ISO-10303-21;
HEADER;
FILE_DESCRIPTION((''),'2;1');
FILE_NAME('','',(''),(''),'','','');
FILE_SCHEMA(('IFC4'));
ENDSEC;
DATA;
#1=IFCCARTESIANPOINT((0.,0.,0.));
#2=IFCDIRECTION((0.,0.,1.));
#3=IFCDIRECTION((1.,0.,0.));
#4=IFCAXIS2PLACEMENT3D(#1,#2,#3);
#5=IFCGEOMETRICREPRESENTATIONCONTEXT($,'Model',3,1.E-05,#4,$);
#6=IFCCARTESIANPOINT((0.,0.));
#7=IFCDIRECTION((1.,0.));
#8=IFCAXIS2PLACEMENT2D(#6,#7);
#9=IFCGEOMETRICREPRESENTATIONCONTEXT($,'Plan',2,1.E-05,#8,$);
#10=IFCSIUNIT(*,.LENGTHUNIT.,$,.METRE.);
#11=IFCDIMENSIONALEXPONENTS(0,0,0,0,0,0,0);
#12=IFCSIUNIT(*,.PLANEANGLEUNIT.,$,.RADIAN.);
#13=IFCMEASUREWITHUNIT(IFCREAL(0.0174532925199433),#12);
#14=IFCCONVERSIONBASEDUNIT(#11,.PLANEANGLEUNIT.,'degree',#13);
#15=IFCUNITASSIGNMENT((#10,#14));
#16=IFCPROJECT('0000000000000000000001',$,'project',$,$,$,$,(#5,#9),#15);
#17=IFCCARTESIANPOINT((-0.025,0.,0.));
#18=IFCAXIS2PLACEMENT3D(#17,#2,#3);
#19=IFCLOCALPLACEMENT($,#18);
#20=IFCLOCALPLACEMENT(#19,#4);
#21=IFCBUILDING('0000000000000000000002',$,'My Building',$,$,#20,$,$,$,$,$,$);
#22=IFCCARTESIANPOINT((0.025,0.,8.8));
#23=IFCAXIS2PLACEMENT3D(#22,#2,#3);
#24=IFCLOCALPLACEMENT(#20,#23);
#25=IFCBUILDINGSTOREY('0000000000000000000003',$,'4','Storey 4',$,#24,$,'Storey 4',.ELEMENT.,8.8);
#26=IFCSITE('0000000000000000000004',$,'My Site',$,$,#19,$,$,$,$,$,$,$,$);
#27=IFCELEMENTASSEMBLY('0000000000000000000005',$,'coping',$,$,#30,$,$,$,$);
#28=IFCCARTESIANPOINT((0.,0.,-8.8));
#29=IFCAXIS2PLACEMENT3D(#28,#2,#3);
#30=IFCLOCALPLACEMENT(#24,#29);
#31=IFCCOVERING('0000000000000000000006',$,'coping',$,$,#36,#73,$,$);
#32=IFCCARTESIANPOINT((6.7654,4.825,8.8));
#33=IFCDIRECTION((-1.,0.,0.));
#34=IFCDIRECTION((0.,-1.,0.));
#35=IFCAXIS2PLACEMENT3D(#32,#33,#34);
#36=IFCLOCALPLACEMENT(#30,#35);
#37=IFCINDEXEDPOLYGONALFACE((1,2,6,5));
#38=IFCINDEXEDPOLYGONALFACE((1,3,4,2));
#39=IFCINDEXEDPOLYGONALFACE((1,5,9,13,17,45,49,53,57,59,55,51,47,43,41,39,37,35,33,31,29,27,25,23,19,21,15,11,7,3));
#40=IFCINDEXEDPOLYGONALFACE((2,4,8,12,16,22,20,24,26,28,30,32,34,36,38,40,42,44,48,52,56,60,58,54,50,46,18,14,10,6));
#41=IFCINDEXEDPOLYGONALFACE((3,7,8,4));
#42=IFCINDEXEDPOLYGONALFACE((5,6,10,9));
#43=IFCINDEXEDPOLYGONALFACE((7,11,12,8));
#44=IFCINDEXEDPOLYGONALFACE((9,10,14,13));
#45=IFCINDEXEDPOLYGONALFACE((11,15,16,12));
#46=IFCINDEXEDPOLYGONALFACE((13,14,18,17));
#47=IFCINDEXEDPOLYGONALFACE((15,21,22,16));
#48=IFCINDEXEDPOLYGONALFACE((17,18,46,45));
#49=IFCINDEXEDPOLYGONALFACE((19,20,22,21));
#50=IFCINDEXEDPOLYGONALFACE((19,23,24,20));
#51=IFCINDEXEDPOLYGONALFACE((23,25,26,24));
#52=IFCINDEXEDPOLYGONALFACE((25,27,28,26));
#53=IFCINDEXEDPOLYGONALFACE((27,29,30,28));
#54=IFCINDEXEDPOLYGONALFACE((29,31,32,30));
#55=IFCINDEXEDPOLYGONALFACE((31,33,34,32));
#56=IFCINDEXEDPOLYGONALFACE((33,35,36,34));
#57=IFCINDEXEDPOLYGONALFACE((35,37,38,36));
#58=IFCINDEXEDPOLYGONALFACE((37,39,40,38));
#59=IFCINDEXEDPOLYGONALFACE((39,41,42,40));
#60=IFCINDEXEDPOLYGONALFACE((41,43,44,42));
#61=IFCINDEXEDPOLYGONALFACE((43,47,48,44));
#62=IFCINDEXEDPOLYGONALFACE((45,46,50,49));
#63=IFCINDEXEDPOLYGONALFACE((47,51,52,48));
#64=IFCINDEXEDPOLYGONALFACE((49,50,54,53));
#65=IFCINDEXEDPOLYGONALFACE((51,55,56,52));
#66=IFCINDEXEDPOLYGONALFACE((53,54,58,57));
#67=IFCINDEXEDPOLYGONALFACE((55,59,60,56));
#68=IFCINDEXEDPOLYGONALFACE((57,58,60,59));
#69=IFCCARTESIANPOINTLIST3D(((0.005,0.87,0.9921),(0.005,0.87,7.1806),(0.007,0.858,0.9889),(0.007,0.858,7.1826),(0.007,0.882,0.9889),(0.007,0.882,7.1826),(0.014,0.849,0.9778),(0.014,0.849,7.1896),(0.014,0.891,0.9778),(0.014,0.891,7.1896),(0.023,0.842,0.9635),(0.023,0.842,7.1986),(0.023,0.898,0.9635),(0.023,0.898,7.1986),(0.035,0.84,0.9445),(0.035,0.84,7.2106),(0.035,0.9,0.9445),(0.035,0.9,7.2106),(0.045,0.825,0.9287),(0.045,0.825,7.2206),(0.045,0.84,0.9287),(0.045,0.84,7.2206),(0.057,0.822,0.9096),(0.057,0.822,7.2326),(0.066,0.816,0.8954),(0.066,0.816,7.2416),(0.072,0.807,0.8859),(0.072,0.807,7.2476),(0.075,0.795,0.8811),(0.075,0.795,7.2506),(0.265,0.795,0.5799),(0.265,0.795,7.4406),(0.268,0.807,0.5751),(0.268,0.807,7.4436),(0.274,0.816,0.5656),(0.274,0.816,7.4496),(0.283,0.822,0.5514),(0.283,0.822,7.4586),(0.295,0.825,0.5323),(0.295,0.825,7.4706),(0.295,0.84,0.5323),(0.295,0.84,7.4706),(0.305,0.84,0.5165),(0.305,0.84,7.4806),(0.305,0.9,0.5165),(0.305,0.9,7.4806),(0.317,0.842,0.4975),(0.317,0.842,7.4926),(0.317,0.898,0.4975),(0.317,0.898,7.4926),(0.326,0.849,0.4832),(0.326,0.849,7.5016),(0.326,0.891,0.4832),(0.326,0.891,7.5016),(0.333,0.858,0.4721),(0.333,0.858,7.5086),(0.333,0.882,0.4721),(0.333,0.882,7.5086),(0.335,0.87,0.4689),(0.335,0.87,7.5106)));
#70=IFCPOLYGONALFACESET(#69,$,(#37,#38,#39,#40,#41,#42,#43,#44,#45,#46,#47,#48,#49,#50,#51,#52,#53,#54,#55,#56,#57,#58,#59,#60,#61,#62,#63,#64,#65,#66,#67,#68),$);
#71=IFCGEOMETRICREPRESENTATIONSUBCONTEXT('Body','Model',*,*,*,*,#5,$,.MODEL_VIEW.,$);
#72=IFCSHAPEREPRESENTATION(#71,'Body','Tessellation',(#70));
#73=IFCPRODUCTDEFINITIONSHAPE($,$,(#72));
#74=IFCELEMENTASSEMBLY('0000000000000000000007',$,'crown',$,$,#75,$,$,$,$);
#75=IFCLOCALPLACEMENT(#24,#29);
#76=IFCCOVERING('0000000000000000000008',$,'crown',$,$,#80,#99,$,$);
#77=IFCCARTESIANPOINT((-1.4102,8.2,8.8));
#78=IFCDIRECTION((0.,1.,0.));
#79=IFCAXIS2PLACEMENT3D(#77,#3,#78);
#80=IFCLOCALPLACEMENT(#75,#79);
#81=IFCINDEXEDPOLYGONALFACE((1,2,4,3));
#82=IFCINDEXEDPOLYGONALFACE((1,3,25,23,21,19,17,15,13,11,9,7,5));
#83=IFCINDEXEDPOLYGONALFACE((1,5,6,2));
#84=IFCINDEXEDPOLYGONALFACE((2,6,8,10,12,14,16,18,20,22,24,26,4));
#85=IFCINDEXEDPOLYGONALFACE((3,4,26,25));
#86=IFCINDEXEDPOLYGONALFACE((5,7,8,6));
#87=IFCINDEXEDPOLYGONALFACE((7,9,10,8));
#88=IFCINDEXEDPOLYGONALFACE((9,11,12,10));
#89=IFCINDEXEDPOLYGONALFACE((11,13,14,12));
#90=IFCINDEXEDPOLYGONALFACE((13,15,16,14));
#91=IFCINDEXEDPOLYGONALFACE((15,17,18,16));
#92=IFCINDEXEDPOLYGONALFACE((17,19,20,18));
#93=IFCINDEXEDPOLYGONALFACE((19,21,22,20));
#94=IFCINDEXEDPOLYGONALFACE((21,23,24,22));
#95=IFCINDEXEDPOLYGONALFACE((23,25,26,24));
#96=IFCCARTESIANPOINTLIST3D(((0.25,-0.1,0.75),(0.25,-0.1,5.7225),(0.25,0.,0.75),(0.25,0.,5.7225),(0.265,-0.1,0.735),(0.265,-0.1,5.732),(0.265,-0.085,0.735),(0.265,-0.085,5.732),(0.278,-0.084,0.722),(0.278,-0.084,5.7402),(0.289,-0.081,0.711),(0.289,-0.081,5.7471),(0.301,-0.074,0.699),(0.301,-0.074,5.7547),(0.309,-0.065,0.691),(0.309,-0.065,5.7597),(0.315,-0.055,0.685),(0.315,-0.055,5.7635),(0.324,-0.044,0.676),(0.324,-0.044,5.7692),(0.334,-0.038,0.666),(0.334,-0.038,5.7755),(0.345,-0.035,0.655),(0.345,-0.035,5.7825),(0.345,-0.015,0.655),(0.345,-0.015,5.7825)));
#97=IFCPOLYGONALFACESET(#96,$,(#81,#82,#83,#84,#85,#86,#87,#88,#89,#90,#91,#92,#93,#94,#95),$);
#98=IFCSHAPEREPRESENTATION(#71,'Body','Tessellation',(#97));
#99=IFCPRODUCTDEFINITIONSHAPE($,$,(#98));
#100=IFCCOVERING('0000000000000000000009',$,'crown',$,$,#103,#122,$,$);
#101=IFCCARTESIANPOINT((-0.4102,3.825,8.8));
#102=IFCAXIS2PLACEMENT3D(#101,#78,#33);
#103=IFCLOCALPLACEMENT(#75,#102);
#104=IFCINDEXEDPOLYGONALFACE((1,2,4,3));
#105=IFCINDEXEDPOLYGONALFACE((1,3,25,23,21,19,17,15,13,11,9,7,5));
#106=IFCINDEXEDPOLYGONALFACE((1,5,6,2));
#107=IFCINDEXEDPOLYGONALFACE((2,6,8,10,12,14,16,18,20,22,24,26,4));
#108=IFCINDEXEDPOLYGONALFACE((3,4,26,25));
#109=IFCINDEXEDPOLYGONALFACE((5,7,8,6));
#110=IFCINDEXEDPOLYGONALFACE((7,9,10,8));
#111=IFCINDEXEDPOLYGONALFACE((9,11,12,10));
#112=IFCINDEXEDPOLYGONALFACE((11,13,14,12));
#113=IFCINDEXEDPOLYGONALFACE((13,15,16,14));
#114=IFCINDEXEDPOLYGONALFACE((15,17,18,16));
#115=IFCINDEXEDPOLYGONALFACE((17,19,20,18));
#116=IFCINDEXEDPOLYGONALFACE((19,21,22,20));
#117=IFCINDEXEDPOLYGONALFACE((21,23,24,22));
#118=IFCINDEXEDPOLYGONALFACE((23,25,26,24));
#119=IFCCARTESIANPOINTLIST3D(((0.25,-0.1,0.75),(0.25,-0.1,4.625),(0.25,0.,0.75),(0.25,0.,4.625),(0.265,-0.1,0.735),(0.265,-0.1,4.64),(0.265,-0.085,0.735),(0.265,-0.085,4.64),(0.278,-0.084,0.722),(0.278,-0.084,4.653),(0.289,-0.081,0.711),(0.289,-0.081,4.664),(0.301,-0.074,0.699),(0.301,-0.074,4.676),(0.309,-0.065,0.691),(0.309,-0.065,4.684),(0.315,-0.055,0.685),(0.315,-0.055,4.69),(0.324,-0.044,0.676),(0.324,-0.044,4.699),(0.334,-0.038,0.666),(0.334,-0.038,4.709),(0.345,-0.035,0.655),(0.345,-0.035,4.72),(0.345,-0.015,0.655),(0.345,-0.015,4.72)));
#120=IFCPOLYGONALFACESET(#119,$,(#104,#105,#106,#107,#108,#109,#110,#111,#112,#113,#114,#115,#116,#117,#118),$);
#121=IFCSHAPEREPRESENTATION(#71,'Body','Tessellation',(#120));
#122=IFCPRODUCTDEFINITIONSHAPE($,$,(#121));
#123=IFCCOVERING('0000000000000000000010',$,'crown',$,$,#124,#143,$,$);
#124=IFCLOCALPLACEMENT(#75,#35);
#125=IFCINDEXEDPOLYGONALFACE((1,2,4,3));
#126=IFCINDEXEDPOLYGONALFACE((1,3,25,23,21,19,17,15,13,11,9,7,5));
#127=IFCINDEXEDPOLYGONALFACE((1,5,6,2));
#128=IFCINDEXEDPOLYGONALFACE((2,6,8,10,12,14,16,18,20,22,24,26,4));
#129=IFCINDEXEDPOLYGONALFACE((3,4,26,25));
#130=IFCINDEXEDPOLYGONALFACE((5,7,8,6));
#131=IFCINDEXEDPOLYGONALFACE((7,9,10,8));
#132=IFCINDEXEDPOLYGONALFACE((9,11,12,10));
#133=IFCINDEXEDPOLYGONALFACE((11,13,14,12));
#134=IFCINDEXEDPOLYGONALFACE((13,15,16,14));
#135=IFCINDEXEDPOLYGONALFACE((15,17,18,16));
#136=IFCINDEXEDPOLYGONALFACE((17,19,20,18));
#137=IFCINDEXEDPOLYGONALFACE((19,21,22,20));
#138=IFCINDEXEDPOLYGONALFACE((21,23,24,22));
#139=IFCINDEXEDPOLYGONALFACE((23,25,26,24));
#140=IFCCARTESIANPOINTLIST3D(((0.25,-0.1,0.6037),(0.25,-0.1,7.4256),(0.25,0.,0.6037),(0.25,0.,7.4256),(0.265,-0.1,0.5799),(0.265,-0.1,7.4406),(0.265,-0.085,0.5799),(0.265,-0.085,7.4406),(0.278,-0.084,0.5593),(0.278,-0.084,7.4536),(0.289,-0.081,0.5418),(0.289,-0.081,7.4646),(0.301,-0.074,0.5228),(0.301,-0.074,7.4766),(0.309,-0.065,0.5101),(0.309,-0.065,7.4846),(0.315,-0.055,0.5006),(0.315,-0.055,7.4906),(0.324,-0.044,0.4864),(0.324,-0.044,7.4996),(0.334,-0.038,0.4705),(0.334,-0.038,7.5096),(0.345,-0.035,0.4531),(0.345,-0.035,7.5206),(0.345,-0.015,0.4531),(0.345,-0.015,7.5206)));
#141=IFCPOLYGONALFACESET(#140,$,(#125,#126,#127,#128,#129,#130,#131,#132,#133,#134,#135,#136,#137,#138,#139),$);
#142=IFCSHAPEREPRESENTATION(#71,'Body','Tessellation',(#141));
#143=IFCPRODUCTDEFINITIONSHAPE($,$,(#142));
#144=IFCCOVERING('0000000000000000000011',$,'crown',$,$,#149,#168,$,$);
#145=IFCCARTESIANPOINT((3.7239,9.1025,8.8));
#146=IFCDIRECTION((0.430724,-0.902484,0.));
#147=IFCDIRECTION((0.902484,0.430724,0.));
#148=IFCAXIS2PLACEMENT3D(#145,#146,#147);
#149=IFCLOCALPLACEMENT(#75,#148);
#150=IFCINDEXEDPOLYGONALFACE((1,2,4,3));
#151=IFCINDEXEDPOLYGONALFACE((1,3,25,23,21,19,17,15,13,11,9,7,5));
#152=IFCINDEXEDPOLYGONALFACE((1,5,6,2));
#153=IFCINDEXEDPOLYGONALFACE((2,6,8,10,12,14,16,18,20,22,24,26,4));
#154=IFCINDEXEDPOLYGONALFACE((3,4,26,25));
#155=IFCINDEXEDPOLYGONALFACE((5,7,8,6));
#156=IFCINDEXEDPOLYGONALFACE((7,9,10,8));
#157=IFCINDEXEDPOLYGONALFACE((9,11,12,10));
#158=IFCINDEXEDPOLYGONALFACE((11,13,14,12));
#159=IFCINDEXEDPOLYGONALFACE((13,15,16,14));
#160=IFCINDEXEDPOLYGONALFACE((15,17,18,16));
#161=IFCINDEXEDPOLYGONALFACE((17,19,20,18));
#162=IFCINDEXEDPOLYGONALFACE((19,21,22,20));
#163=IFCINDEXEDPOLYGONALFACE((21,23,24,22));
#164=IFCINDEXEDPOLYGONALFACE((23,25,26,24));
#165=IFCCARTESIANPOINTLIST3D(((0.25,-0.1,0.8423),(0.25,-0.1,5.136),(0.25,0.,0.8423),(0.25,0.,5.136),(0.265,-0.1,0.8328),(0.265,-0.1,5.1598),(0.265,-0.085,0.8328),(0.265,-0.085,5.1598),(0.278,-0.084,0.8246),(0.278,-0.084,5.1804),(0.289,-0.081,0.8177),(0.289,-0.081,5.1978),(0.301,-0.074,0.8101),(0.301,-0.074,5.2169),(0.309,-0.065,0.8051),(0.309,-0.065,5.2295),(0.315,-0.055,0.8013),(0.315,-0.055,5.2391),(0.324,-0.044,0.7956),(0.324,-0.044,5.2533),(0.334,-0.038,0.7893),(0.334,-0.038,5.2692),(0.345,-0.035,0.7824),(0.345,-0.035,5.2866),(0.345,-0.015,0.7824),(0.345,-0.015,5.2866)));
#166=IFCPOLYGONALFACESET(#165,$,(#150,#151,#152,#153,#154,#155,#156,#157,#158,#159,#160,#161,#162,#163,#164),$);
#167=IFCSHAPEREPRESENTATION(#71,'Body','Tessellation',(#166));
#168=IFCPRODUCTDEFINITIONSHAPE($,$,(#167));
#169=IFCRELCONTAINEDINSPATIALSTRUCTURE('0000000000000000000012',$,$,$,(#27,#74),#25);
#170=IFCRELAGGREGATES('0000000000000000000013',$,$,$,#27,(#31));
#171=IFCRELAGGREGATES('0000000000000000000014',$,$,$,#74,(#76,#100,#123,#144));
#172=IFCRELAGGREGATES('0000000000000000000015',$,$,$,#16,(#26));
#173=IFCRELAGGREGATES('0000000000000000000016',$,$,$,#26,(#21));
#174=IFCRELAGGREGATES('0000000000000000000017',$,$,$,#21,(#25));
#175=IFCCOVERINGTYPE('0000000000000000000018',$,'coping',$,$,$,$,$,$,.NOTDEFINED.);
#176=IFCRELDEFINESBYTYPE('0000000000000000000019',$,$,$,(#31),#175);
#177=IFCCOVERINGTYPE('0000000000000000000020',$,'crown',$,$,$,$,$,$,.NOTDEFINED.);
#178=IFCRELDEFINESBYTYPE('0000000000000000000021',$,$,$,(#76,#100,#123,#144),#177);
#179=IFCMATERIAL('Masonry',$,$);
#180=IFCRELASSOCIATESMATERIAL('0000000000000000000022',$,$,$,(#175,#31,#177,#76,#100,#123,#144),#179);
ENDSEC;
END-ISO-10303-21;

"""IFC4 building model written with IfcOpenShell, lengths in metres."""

from ifc_helpers import new_model, entity, si_unit, converted_unit, frame, origin_with_axes, origin_2d_with_axis, place, context, subcontext, project, spatial, polyline, outline, extrude, clip, halfspace, material, material_profile, profile_set, profile_usage, type_object, element, aggregate, save


model = new_model("IFC4")

# Units and contexts
model_context = context("Model", 3, precision=1e-05, world=origin_with_axes())
plan_context = context("Plan", 2, precision=1e-05, world=origin_2d_with_axis())
body_context = subcontext(model_context, "Body", "Model", "MODEL_VIEW")
ifc_project = project(units=[si_unit("LENGTHUNIT", "METRE"), converted_unit("PLANEANGLEUNIT", "degree", entity("IfcReal", 0.0174532925199433), si_unit("PLANEANGLEUNIT", "RADIAN"), dimensions=[0, 0, 0, 0, 0, 0, 0])], contexts=[model_context, plan_context])

# Site, building, storey
site_placement = place(None, frame((-0.025, 0.0, 0.0), z_axis=(0.0, 0.0, 1.0), x_axis=(1.0, 0.0, 0.0)))
site = spatial("IfcSite", under=ifc_project, at=site_placement, Name="My Site")
building_placement = place(site_placement, origin_with_axes())
building = spatial("IfcBuilding", under=site, at=building_placement, Name="My Building")
storey_placement = place(building_placement, frame((0.025, 0.0, 8.8), z_axis=(0.0, 0.0, 1.0), x_axis=(1.0, 0.0, 0.0)))
storey = spatial("IfcBuildingStorey", under=building, at=storey_placement, Name="4", Description="Storey 4", LongName="Storey 4", CompositionType="ELEMENT", Elevation=8.8)

# Shared definitions
ifc_material_1 = material(Name="Masonry")

# Element assemblies, coverings
assembly_1_placement = place(storey_placement, frame((0.0, 0.0, -8.8), z_axis=(0.0, 0.0, 1.0), x_axis=(1.0, 0.0, 0.0)))
assembly_1 = element("IfcElementAssembly", 1, at=assembly_1_placement, inside=storey, Name="coping")
ifc_material_profile_1 = material_profile(ifc_material_1, outline(polyline([(0.265, 0.795), (0.268, 0.807), (0.274, 0.816), (0.283, 0.822), (0.295, 0.825), (0.295, 0.84), (0.305, 0.84), (0.317, 0.842), (0.326, 0.849), (0.333, 0.858), (0.335, 0.87), (0.333, 0.882), (0.326, 0.891), (0.317, 0.898), (0.305, 0.9), (0.035, 0.9), (0.023, 0.898), (0.014, 0.891), (0.007, 0.882), (0.005, 0.87), (0.007, 0.858), (0.014, 0.849), (0.023, 0.842), (0.035, 0.84), (0.045, 0.84), (0.045, 0.825), (0.057, 0.822), (0.066, 0.816), (0.072, 0.807), (0.075, 0.795), (0.265, 0.795)])))
ifc_profile_set_1 = profile_set([ifc_material_profile_1])
covering_type_1 = type_object("IfcCoveringType", Name="coping", PredefinedType="NOTDEFINED", material=ifc_profile_set_1)
ifc_profile_usage_1 = profile_usage(ifc_profile_set_1)
covering_1_placement = place(assembly_1_placement, frame((6.7654, 4.825, 8.8), z_axis=(-1.0, 0.0, 0.0), x_axis=(0.0, -1.0, 0.0)))
covering_1 = element("IfcCovering", 2, at=covering_1_placement, type_object=covering_type_1, material=ifc_profile_usage_1, Name="coping", context=body_context, shape_type="Clipping", body=[
    clip(clip(extrude(outline(polyline([(0.265, 0.795), (0.268, 0.807), (0.274, 0.816), (0.283, 0.822), (0.295, 0.825), (0.295, 0.84), (0.305, 0.84), (0.317, 0.842), (0.326, 0.849), (0.333, 0.858), (0.335, 0.87), (0.333, 0.882), (0.326, 0.891), (0.317, 0.898), (0.305, 0.9), (0.035, 0.9), (0.023, 0.898), (0.014, 0.891), (0.007, 0.882), (0.005, 0.87), (0.007, 0.858), (0.014, 0.849), (0.023, 0.842), (0.035, 0.84), (0.045, 0.84), (0.045, 0.825), (0.057, 0.822), (0.066, 0.816), (0.072, 0.807), (0.075, 0.795), (0.265, 0.795)])), origin_with_axes(), (0.0, 0.0, 1.0), 8.1756), halfspace(frame((0.0, -8.8, 1.0), z_axis=(-0.845791, 0.0, -0.533515), x_axis=(0.0, 1.0, 0.0)), False)), halfspace(frame((0.0, -8.8, 7.1756), z_axis=(-0.707107, 0.0, 0.707107), x_axis=(0.0, 1.0, 0.0)), False)),
])
aggregate(assembly_1, [covering_1])
assembly_2_placement = place(storey_placement, frame((0.0, 0.0, -8.8), z_axis=(0.0, 0.0, 1.0), x_axis=(1.0, 0.0, 0.0)))
assembly_2 = element("IfcElementAssembly", 3, at=assembly_2_placement, inside=storey, Name="crown")
ifc_material_profile_2 = material_profile(ifc_material_1, outline(polyline([(0.25, -0.1), (0.265, -0.1), (0.265, -0.085), (0.278, -0.084), (0.289, -0.081), (0.301, -0.074), (0.309, -0.065), (0.315, -0.055), (0.324, -0.044), (0.334, -0.038), (0.345, -0.035), (0.345, -0.015), (0.25, 0.0), (0.25, -0.1)])))
ifc_profile_set_2 = profile_set([ifc_material_profile_2])
ifc_profile_usage_2 = profile_usage(ifc_profile_set_2)
covering_type_2 = type_object("IfcCoveringType", Name="crown", PredefinedType="NOTDEFINED", material=ifc_profile_set_2)
covering_2_placement = place(assembly_2_placement, frame((-1.4102, 8.2, 8.8), z_axis=(1.0, 0.0, 0.0), x_axis=(0.0, 1.0, 0.0)))
covering_2 = element("IfcCovering", 4, at=covering_2_placement, type_object=covering_type_2, material=ifc_profile_usage_2, Name="crown", context=body_context, shape_type="Clipping", body=[
    clip(clip(extrude(outline(polyline([(0.25, -0.1), (0.265, -0.1), (0.265, -0.085), (0.278, -0.084), (0.289, -0.081), (0.301, -0.074), (0.309, -0.065), (0.315, -0.055), (0.324, -0.044), (0.334, -0.038), (0.345, -0.035), (0.345, -0.015), (0.25, 0.0), (0.25, -0.1)])), origin_with_axes(), (0.0, 0.0, 1.0), 6.5648), halfspace(frame((0.0, -8.8, 1.0), z_axis=(-0.707107, 0.0, -0.707107), x_axis=(0.0, 1.0, 0.0)), False)), halfspace(frame((0.0, -8.8, 5.5648), z_axis=(-0.533515, 0.0, 0.845791), x_axis=(0.0, 1.0, 0.0)), False)),
])
ifc_profile_usage_3 = profile_usage(ifc_profile_set_2)
covering_3_placement = place(assembly_2_placement, frame((-0.4102, 3.825, 8.8), z_axis=(0.0, 1.0, 0.0), x_axis=(-1.0, 0.0, 0.0)))
covering_3 = element("IfcCovering", 5, at=covering_3_placement, type_object=covering_type_2, material=ifc_profile_usage_3, Name="crown", context=body_context, shape_type="Clipping", body=[
    clip(clip(extrude(outline(polyline([(0.25, -0.1), (0.265, -0.1), (0.265, -0.085), (0.278, -0.084), (0.289, -0.081), (0.301, -0.074), (0.309, -0.065), (0.315, -0.055), (0.324, -0.044), (0.334, -0.038), (0.345, -0.035), (0.345, -0.015), (0.25, 0.0), (0.25, -0.1)])), origin_with_axes(), (0.0, 0.0, 1.0), 5.375), halfspace(frame((0.0, -8.8, 1.0), z_axis=(-0.707107, 0.0, -0.707107), x_axis=(0.0, 1.0, 0.0)), False)), halfspace(frame((0.0, -8.8, 4.375), z_axis=(-0.707107, 0.0, 0.707107), x_axis=(0.0, 1.0, 0.0)), False)),
])
ifc_profile_usage_4 = profile_usage(ifc_profile_set_2)
covering_4_placement = place(assembly_2_placement, frame((6.7654, 4.825, 8.8), z_axis=(-1.0, 0.0, 0.0), x_axis=(0.0, -1.0, 0.0)))
covering_4 = element("IfcCovering", 6, at=covering_4_placement, type_object=covering_type_2, material=ifc_profile_usage_4, Name="crown", context=body_context, shape_type="Clipping", body=[
    clip(clip(extrude(outline(polyline([(0.25, -0.1), (0.265, -0.1), (0.265, -0.085), (0.278, -0.084), (0.289, -0.081), (0.301, -0.074), (0.309, -0.065), (0.315, -0.055), (0.324, -0.044), (0.334, -0.038), (0.345, -0.035), (0.345, -0.015), (0.25, 0.0), (0.25, -0.1)])), origin_with_axes(), (0.0, 0.0, 1.0), 8.1756), halfspace(frame((0.0, -8.8, 1.0), z_axis=(-0.845791, 0.0, -0.533515), x_axis=(0.0, 1.0, 0.0)), False)), halfspace(frame((0.0, -8.8, 7.1756), z_axis=(-0.707107, 0.0, 0.707107), x_axis=(0.0, 1.0, 0.0)), False)),
])
ifc_profile_usage_5 = profile_usage(ifc_profile_set_2)
covering_5_placement = place(assembly_2_placement, frame((3.7239, 9.1025, 8.8), z_axis=(0.430724, -0.902484, 0.0), x_axis=(0.902484, 0.430724, 0.0)))
covering_5 = element("IfcCovering", 7, at=covering_5_placement, type_object=covering_type_2, material=ifc_profile_usage_5, Name="crown", context=body_context, shape_type="Clipping", body=[
    clip(clip(extrude(outline(polyline([(0.25, -0.1), (0.265, -0.1), (0.265, -0.085), (0.278, -0.084), (0.289, -0.081), (0.301, -0.074), (0.309, -0.065), (0.315, -0.055), (0.324, -0.044), (0.334, -0.038), (0.345, -0.035), (0.345, -0.015), (0.25, 0.0), (0.25, -0.1)])), origin_with_axes(), (0.0, 0.0, 1.0), 5.7397), halfspace(frame((0.0, -8.8, 1.0), z_axis=(-0.533515, 0.0, -0.845791), x_axis=(0.0, 1.0, 0.0)), False)), halfspace(frame((0.0, -8.8, 4.7397), z_axis=(-0.845791, 0.0, 0.533515), x_axis=(0.0, 1.0, 0.0)), False)),
])
aggregate(assembly_2, [covering_2, covering_3, covering_4, covering_5])

save(model, "model.ifc")
